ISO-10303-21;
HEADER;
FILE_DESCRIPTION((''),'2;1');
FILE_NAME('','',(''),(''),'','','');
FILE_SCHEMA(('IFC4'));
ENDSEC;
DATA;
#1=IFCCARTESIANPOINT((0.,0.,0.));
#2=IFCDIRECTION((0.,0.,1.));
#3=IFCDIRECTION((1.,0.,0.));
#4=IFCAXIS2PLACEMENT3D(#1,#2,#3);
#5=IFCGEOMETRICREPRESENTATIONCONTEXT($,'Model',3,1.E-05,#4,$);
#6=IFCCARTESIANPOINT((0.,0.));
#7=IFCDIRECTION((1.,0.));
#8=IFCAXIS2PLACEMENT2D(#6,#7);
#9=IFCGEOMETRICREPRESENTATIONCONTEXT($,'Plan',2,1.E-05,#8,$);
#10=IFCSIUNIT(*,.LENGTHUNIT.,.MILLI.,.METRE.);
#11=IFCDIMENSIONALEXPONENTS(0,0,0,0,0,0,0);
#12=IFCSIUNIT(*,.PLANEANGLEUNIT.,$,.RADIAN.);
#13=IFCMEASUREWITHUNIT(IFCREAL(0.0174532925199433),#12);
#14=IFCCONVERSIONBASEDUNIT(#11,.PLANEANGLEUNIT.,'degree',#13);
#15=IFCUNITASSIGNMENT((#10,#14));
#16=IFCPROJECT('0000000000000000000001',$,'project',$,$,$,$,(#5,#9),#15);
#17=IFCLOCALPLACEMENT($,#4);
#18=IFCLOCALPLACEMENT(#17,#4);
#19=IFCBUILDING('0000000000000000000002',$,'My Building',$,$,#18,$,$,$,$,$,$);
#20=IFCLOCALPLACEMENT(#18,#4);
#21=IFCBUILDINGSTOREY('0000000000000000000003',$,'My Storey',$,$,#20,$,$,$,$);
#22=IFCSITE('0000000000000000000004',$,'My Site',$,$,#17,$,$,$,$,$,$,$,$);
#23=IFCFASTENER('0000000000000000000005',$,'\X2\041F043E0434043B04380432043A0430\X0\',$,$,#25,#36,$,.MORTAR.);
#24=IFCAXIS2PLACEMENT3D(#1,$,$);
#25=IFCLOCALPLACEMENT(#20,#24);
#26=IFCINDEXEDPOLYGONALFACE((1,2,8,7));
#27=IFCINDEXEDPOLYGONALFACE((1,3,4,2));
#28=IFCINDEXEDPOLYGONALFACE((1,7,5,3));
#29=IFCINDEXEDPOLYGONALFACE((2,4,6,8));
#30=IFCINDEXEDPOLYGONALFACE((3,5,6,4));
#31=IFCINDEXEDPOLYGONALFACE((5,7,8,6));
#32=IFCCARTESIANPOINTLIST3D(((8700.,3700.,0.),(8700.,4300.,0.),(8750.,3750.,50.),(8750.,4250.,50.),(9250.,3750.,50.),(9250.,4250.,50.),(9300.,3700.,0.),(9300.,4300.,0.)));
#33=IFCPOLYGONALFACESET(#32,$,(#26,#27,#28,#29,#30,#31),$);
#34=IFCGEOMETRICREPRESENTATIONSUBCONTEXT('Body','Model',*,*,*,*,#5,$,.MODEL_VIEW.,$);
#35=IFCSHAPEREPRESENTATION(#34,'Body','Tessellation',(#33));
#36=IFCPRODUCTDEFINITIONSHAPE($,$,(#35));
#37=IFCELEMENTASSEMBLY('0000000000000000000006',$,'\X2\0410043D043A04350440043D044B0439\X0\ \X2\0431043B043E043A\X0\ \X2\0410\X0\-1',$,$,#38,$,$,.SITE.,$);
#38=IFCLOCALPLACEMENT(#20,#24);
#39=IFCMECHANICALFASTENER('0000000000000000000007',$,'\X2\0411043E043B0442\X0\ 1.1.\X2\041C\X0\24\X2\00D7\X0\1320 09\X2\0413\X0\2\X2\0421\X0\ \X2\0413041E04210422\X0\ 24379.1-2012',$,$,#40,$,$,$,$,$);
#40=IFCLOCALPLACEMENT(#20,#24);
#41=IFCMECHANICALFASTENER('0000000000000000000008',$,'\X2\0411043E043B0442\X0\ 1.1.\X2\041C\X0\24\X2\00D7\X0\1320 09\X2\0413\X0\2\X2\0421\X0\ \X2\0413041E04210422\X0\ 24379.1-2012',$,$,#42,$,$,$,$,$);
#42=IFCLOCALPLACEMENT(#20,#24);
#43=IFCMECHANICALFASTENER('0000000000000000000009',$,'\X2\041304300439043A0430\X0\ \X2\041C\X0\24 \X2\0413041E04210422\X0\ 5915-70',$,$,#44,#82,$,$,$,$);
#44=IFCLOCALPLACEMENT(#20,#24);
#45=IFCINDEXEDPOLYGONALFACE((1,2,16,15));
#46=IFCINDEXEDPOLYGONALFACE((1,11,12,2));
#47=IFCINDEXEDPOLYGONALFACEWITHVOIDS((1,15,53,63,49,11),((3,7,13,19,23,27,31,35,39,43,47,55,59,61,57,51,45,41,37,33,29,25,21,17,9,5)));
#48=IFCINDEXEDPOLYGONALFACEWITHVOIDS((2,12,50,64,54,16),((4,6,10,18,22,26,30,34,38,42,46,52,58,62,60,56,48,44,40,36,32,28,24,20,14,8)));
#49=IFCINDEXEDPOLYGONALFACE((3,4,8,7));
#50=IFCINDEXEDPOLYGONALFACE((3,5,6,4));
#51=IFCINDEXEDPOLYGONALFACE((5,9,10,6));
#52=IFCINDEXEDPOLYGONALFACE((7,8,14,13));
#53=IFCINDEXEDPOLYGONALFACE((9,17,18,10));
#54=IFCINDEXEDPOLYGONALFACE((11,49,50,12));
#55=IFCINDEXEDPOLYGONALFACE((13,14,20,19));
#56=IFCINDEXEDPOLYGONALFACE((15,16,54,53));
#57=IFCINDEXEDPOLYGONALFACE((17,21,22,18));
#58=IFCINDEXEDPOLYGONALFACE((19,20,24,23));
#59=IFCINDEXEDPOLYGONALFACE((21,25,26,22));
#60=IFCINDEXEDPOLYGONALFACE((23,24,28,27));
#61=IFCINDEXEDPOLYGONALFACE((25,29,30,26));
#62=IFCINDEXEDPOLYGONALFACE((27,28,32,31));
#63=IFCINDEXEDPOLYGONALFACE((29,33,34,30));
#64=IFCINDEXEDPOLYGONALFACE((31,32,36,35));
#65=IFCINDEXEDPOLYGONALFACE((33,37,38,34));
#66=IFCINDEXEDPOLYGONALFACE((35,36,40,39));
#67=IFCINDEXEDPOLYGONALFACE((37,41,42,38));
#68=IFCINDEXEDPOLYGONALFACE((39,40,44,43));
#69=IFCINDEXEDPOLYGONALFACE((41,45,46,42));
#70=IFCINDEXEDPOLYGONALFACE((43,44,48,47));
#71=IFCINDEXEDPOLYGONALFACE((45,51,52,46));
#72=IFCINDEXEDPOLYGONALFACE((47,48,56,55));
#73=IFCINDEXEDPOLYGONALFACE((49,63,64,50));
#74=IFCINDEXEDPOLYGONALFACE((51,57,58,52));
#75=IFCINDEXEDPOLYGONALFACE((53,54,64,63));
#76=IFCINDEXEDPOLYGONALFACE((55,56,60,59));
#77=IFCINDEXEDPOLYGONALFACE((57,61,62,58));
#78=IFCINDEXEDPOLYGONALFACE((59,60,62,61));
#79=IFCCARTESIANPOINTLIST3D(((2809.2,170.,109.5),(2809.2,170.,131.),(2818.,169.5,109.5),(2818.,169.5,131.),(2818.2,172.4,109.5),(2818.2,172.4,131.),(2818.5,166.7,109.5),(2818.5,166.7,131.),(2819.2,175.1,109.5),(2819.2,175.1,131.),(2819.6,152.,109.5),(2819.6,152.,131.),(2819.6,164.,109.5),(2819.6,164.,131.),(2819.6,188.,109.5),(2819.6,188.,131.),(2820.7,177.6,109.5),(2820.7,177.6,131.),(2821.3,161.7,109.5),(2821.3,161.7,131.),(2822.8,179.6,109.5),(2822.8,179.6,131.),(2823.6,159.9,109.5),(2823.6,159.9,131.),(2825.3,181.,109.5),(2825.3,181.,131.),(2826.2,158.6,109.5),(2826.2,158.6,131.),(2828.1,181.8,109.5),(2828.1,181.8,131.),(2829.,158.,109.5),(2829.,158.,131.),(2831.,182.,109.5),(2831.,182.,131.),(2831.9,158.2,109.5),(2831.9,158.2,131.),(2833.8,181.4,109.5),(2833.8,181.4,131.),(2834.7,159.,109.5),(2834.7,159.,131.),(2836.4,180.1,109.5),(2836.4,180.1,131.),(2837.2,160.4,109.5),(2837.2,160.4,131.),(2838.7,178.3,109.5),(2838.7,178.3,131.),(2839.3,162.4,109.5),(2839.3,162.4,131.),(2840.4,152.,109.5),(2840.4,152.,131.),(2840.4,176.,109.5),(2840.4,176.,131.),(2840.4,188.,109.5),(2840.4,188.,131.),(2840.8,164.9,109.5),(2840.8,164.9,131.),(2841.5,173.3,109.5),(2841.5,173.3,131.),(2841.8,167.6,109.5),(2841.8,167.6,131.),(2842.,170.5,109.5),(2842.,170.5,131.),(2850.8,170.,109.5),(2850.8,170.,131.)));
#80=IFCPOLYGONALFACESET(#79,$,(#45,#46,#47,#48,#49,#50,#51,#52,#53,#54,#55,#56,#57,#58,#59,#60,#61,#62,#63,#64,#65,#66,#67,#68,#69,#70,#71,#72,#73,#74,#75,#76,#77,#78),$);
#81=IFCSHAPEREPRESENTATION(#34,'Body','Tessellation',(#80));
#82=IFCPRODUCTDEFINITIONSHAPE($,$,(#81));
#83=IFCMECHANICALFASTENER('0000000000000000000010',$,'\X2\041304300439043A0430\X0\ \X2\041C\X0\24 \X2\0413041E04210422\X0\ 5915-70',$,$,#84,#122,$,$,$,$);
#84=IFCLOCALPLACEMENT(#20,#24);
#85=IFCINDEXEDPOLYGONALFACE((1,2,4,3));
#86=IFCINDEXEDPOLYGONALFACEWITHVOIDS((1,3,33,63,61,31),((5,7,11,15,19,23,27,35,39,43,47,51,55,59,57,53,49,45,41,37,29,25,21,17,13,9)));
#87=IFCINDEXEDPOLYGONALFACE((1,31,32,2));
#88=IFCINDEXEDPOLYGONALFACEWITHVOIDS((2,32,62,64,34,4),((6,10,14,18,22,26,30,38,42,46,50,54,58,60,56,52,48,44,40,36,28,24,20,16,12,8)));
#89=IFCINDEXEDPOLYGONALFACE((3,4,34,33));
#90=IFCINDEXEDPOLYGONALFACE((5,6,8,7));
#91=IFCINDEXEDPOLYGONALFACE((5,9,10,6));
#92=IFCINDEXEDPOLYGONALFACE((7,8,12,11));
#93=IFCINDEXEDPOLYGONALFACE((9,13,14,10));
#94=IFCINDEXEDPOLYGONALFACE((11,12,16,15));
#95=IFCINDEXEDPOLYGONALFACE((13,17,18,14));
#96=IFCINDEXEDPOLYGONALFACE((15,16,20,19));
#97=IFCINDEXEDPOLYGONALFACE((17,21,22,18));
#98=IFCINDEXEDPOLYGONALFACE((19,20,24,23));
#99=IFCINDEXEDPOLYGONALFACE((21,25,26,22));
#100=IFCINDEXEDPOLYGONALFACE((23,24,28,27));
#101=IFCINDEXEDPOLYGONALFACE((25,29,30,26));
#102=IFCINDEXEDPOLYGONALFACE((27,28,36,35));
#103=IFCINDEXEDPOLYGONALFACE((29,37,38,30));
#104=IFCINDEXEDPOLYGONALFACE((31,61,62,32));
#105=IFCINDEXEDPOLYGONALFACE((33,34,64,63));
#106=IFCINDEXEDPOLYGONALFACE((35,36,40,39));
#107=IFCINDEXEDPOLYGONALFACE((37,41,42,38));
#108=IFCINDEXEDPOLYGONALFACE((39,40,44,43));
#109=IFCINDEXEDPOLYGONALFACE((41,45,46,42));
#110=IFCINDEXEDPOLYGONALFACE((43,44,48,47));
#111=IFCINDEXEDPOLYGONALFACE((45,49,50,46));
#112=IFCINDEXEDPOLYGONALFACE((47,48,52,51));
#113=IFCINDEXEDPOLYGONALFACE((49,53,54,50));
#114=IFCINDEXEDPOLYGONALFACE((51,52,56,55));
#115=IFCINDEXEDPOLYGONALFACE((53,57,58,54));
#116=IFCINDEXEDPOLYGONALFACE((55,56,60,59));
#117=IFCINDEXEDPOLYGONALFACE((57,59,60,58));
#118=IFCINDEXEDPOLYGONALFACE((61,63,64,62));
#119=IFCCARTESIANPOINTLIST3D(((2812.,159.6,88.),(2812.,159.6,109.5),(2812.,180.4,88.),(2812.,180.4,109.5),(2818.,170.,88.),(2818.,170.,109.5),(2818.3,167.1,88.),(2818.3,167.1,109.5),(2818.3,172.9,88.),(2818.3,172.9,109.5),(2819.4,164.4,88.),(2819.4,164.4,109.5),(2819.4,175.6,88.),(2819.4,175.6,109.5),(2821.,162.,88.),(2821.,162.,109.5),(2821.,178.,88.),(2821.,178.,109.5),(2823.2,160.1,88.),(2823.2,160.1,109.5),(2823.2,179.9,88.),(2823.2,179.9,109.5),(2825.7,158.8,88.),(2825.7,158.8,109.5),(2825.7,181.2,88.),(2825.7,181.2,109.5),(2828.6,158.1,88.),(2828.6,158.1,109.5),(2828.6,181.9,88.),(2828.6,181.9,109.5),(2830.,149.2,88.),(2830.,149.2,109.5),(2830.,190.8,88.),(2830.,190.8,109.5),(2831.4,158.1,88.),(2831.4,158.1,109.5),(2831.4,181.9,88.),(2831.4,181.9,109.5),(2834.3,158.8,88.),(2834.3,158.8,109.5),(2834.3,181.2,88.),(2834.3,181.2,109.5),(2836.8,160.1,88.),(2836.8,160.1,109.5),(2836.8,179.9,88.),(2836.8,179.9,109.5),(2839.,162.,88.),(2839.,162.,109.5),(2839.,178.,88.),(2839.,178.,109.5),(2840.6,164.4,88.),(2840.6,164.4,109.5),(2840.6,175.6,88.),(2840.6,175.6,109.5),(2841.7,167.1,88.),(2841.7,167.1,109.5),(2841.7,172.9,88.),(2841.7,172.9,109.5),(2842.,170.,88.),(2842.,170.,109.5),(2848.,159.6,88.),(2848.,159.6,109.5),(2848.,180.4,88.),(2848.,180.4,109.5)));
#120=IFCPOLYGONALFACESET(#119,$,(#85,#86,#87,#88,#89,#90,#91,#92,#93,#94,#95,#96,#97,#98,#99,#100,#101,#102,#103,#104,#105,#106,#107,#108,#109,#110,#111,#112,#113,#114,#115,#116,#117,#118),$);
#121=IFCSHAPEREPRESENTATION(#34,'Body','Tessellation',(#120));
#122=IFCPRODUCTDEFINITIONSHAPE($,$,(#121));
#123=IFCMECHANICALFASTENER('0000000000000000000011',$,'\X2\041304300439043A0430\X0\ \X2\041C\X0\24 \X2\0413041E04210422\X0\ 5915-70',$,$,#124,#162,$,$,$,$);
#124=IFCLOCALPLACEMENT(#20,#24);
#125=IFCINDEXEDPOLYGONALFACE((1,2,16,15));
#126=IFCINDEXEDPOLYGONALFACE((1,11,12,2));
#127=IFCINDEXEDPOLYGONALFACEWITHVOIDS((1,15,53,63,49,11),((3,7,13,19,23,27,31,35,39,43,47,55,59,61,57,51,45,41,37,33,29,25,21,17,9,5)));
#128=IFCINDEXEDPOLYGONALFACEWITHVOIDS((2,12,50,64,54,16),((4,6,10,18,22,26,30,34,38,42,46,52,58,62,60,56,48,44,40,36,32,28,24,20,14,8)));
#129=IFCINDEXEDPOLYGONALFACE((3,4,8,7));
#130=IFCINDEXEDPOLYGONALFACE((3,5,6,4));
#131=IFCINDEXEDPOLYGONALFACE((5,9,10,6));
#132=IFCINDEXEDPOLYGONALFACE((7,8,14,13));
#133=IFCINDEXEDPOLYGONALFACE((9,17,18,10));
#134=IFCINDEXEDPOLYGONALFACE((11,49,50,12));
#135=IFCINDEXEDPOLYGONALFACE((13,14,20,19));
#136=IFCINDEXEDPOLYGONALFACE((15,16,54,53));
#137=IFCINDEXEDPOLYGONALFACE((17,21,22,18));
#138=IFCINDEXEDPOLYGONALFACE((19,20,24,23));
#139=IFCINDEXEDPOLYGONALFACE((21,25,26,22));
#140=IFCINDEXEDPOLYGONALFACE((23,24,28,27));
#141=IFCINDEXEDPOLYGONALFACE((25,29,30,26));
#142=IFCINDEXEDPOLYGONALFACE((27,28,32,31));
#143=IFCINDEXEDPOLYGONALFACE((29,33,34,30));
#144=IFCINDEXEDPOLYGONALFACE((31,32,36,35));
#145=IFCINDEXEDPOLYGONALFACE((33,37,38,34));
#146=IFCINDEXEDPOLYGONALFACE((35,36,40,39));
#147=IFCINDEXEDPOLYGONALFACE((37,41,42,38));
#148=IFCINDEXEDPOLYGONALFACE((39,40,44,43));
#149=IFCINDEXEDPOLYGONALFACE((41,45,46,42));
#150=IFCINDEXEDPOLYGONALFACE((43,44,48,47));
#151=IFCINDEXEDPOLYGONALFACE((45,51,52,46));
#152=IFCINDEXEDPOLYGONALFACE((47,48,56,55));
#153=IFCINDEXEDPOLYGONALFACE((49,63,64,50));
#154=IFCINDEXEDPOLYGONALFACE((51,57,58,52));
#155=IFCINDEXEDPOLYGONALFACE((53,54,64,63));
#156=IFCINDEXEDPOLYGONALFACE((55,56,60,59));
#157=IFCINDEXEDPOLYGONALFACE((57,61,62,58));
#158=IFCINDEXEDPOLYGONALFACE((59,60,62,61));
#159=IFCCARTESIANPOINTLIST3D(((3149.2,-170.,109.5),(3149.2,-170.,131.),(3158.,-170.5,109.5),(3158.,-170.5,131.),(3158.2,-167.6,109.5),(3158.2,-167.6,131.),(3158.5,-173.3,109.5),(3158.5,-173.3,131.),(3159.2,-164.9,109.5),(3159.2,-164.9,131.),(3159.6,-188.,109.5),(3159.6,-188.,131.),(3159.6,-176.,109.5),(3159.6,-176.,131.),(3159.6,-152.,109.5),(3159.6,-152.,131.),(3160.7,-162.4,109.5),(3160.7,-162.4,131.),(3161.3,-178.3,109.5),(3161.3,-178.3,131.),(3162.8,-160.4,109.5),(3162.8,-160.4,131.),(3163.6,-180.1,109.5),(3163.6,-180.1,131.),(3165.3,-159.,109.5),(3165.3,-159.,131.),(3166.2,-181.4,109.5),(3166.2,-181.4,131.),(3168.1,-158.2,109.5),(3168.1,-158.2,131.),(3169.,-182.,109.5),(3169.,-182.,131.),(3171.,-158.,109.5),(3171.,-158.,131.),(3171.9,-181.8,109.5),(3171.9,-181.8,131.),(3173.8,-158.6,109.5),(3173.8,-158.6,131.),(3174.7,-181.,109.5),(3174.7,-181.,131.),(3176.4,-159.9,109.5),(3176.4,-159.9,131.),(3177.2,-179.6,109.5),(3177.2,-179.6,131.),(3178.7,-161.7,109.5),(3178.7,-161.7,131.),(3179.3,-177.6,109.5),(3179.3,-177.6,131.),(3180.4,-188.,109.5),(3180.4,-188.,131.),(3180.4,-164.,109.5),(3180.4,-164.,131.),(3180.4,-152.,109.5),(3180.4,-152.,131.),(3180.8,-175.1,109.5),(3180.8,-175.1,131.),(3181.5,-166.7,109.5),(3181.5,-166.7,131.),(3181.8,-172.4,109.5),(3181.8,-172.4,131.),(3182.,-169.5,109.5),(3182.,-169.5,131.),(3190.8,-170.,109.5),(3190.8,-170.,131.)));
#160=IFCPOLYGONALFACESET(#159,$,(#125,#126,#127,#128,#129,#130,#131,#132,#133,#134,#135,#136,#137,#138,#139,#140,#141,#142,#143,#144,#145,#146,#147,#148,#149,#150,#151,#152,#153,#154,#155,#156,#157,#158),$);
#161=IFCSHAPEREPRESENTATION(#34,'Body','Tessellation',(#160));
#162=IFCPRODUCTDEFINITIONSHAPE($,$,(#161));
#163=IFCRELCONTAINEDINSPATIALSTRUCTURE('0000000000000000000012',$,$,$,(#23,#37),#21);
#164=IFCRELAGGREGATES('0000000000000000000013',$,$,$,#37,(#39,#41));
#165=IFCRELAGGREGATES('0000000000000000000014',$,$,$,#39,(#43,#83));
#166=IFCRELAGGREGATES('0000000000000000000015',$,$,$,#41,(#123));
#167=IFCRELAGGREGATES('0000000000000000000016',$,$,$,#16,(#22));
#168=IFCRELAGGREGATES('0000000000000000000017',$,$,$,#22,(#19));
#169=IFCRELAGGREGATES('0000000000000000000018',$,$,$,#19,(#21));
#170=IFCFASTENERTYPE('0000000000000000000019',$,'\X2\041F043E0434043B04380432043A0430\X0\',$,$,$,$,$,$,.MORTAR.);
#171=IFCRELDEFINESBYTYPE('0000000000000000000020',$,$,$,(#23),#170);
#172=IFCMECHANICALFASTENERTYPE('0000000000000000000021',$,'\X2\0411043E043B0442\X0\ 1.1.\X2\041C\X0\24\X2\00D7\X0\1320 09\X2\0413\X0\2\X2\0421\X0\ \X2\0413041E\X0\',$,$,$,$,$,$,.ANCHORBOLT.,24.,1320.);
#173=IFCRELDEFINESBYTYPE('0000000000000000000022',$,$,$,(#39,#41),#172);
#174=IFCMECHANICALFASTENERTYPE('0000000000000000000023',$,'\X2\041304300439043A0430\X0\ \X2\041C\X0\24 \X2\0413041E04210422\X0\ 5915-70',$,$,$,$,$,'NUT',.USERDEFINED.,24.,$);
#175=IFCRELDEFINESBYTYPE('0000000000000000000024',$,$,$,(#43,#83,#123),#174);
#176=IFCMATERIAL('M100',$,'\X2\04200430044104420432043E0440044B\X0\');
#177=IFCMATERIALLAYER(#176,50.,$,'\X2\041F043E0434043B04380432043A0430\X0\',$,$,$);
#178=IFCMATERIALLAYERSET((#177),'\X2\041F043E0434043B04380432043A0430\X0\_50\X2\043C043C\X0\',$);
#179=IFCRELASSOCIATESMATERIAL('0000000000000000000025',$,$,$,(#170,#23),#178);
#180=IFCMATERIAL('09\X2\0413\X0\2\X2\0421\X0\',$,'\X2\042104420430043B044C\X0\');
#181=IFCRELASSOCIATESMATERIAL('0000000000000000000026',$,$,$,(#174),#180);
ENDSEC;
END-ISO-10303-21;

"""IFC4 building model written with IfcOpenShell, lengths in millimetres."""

from ifc_helpers import new_model, entity, si_unit, converted_unit, frame, origin_with_axes, origin_2d_with_axis, place, context, subcontext, project, spatial, polyline, line, indexed_curve, outline, extrude, clip, halfspace, source, transform, mapped, material, layer, layer_set, layer_usage, type_object, type_shapes, element, aggregate, save


model = new_model("IFC4")

# Units and contexts
model_context = context("Model", 3, precision=1e-05, world=origin_with_axes())
plan_context = context("Plan", 2, precision=1e-05, world=origin_2d_with_axis())
body_context = subcontext(model_context, "Body", "Model", "MODEL_VIEW")
ifc_project = project(units=[si_unit("LENGTHUNIT", "METRE", prefix="MILLI"), converted_unit("PLANEANGLEUNIT", "degree", entity("IfcReal", 0.0174532925199433), si_unit("PLANEANGLEUNIT", "RADIAN"), dimensions=[0, 0, 0, 0, 0, 0, 0])], contexts=[model_context, plan_context])

# Site, building, storey
site_placement = place(None, origin_with_axes())
site = spatial("IfcSite", under=ifc_project, at=site_placement, Name="My Site")
building_placement = place(site_placement, origin_with_axes())
building = spatial("IfcBuilding", under=site, at=building_placement, Name="My Building")
storey_placement = place(building_placement, origin_with_axes())
storey = spatial("IfcBuildingStorey", under=building, at=storey_placement, Name="My Storey")

# Fastener
ifc_material_1 = material(Name="M100", Category="Растворы")
ifc_layer_1 = layer(ifc_material_1, 50.0, Name="Подливка")
ifc_layer_set_1 = layer_set([ifc_layer_1], Name="Подливка_50мм")
fastener_type = type_object("IfcFastenerType", Name="Подливка", PredefinedType="MORTAR", material=ifc_layer_set_1)
ifc_layer_usage_1 = layer_usage(ifc_layer_set_1, "AXIS3", "POSITIVE", 0.0)
fastener_1_placement = place(storey_placement, frame((9000.0, 4000.0, 0.0), z_axis=(0.0, 0.0, 1.0), x_axis=(1.0, 0.0, 0.0)))
element("IfcFastener", 1, at=fastener_1_placement, inside=storey, type_object=fastener_type, material=ifc_layer_usage_1, Name="Подливка", PredefinedType="MORTAR", context=body_context, shape_type="Clipping", body=[
    clip(clip(clip(clip(extrude(outline(indexed_curve([(-300.0, -300.0), (300.0, -300.0), (300.0, 300.0), (-300.0, 300.0)], segments=[line(3, 2), line(2, 1), line(1, 4), line(4, 3)], self_intersect=False)), None, (0.0, 0.0, 1.0), 50.0), halfspace(frame((-53.6, 200.0, 353.6), z_axis=(0.707107, 0.0, 0.707107), x_axis=(0.707107, 0.0, -0.707107)), False)), halfspace(frame((-200.0, -53.6, 353.6), z_axis=(0.0, 0.707107, 0.707107), x_axis=(0.0, 0.707107, -0.707107)), False)), halfspace(frame((200.0, 53.6, 353.6), z_axis=(0.0, -0.707107, 0.707107), x_axis=(0.0, -0.707107, -0.707107)), False)), halfspace(frame((53.6, 200.0, 353.6), z_axis=(-0.707107, 0.0, 0.707107), x_axis=(-0.707107, 0.0, -0.707107)), False)),
])

# Element assembly, mechanical fasteners
assembly_placement = place(storey_placement, frame((3000.0, 0.0, 0.0), z_axis=(0.0, 0.0, 1.0), x_axis=(1.0, 0.0, 0.0)))
assembly = element("IfcElementAssembly", 2, at=assembly_placement, inside=storey, Name="Анкерный блок А-1", AssemblyPlace="SITE")
mechanical_fastener_type_1 = type_object("IfcMechanicalFastenerType", Name="Болт 1.1.М24×1320 09Г2С ГО", NominalDiameter=24.0, NominalLength=1320.0, PredefinedType="ANCHORBOLT")
mechanical_fastener_1_placement = place(assembly_placement, frame((-170.0, 170.0, 0.0), z_axis=(0.0, 0.0, 1.0), x_axis=(-1.0, 0.0, 0.0)))
mechanical_fastener_1 = element("IfcMechanicalFastener", 3, at=mechanical_fastener_1_placement, type_object=mechanical_fastener_type_1, Name="Болт 1.1.М24×1320 09Г2С ГОСТ 24379.1-2012")
ifc_material_2 = material(Name="09Г2С", Category="Сталь")
mechanical_fastener_2_placement = place(assembly_placement, frame((170.0, -170.0, 0.0), z_axis=(0.0, 0.0, 1.0), x_axis=(1.0, 0.0, 0.0)))
mechanical_fastener_2 = element("IfcMechanicalFastener", 4, at=mechanical_fastener_2_placement, type_object=mechanical_fastener_type_1, Name="Болт 1.1.М24×1320 09Г2С ГОСТ 24379.1-2012")
aggregate(assembly, [mechanical_fastener_1, mechanical_fastener_2])
mechanical_fastener_type_2 = type_object("IfcMechanicalFastenerType", Name="Гайка М24 ГОСТ 5915-70", ElementType="NUT", NominalDiameter=24.0, PredefinedType="USERDEFINED", material=ifc_material_2)
shared_shape_1 = source(origin_with_axes(), body_context, "Body", "SweptSolid", [
    extrude(outline(polyline([(-10.4, -18.0), (10.4, -18.0), (20.8, 0.0), (10.4, 18.0), (-10.4, 18.0), (-20.8, 0.0), (-10.4, -18.0)]), holes=[polyline([(-8.0, 9.0), (-5.6, 10.6), (-2.9, 11.7), (0.0, 12.0), (2.9, 11.7), (5.6, 10.6), (8.0, 9.0), (9.9, 6.8), (11.2, 4.3), (11.9, 1.4), (11.9, -1.4), (11.2, -4.3), (9.9, -6.8), (8.0, -9.0), (5.6, -10.6), (2.9, -11.7), (0.0, -12.0), (-2.9, -11.7), (-5.6, -10.6), (-8.0, -9.0), (-9.9, -6.8), (-11.2, -4.3), (-11.9, -1.4), (-11.9, 1.4), (-11.2, 4.3), (-9.9, 6.8), (-8.0, 9.0)])]), frame((0.0, 0.0, 0.0), z_axis=(0.0, 0.0, 1.0), x_axis=(0.0, 1.0, 0.0)), (0.0, 0.0, 1.0), 21.5),
])
type_shapes(mechanical_fastener_type_2, [shared_shape_1])
mechanical_fastener_3_placement = place(mechanical_fastener_1_placement, frame((0.0, 0.0, 109.5), z_axis=(0.0, 0.0, 1.0), x_axis=(0.866025, 0.5, 0.0)))
mechanical_fastener_3 = element("IfcMechanicalFastener", 5, at=mechanical_fastener_3_placement, type_object=mechanical_fastener_type_2, Name="Гайка М24 ГОСТ 5915-70", context=body_context, shape_type="MappedRepresentation", body=[
    mapped(shared_shape_1, transform((0.0, 0.0, 0.0), x_axis=(1.0, 0.0, 0.0), y_axis=(0.0, 1.0, 0.0), z_axis=(0.0, 0.0, 1.0), scale=1.0)),
])
mechanical_fastener_4_placement = place(mechanical_fastener_1_placement, frame((0.0, 0.0, 88.0), z_axis=(0.0, 0.0, 1.0), x_axis=(1.0, 0.0, 0.0)))
mechanical_fastener_4 = element("IfcMechanicalFastener", 6, at=mechanical_fastener_4_placement, type_object=mechanical_fastener_type_2, Name="Гайка М24 ГОСТ 5915-70", context=body_context, shape_type="MappedRepresentation", body=[
    mapped(shared_shape_1, transform((0.0, 0.0, 0.0), x_axis=(1.0, 0.0, 0.0), y_axis=(0.0, 1.0, 0.0), z_axis=(0.0, 0.0, 1.0), scale=1.0)),
])
mechanical_fastener_5_placement = place(mechanical_fastener_2_placement, frame((0.0, 0.0, 109.5), z_axis=(0.0, 0.0, 1.0), x_axis=(0.866025, 0.5, 0.0)))
mechanical_fastener_5 = element("IfcMechanicalFastener", 7, at=mechanical_fastener_5_placement, type_object=mechanical_fastener_type_2, Name="Гайка М24 ГОСТ 5915-70", context=body_context, shape_type="MappedRepresentation", body=[
    mapped(shared_shape_1, transform((0.0, 0.0, 0.0), x_axis=(1.0, 0.0, 0.0), y_axis=(0.0, 1.0, 0.0), z_axis=(0.0, 0.0, 1.0), scale=1.0)),
])
aggregate(mechanical_fastener_1, [mechanical_fastener_3, mechanical_fastener_4])
aggregate(mechanical_fastener_2, [mechanical_fastener_5])

save(model, "model.ifc")
